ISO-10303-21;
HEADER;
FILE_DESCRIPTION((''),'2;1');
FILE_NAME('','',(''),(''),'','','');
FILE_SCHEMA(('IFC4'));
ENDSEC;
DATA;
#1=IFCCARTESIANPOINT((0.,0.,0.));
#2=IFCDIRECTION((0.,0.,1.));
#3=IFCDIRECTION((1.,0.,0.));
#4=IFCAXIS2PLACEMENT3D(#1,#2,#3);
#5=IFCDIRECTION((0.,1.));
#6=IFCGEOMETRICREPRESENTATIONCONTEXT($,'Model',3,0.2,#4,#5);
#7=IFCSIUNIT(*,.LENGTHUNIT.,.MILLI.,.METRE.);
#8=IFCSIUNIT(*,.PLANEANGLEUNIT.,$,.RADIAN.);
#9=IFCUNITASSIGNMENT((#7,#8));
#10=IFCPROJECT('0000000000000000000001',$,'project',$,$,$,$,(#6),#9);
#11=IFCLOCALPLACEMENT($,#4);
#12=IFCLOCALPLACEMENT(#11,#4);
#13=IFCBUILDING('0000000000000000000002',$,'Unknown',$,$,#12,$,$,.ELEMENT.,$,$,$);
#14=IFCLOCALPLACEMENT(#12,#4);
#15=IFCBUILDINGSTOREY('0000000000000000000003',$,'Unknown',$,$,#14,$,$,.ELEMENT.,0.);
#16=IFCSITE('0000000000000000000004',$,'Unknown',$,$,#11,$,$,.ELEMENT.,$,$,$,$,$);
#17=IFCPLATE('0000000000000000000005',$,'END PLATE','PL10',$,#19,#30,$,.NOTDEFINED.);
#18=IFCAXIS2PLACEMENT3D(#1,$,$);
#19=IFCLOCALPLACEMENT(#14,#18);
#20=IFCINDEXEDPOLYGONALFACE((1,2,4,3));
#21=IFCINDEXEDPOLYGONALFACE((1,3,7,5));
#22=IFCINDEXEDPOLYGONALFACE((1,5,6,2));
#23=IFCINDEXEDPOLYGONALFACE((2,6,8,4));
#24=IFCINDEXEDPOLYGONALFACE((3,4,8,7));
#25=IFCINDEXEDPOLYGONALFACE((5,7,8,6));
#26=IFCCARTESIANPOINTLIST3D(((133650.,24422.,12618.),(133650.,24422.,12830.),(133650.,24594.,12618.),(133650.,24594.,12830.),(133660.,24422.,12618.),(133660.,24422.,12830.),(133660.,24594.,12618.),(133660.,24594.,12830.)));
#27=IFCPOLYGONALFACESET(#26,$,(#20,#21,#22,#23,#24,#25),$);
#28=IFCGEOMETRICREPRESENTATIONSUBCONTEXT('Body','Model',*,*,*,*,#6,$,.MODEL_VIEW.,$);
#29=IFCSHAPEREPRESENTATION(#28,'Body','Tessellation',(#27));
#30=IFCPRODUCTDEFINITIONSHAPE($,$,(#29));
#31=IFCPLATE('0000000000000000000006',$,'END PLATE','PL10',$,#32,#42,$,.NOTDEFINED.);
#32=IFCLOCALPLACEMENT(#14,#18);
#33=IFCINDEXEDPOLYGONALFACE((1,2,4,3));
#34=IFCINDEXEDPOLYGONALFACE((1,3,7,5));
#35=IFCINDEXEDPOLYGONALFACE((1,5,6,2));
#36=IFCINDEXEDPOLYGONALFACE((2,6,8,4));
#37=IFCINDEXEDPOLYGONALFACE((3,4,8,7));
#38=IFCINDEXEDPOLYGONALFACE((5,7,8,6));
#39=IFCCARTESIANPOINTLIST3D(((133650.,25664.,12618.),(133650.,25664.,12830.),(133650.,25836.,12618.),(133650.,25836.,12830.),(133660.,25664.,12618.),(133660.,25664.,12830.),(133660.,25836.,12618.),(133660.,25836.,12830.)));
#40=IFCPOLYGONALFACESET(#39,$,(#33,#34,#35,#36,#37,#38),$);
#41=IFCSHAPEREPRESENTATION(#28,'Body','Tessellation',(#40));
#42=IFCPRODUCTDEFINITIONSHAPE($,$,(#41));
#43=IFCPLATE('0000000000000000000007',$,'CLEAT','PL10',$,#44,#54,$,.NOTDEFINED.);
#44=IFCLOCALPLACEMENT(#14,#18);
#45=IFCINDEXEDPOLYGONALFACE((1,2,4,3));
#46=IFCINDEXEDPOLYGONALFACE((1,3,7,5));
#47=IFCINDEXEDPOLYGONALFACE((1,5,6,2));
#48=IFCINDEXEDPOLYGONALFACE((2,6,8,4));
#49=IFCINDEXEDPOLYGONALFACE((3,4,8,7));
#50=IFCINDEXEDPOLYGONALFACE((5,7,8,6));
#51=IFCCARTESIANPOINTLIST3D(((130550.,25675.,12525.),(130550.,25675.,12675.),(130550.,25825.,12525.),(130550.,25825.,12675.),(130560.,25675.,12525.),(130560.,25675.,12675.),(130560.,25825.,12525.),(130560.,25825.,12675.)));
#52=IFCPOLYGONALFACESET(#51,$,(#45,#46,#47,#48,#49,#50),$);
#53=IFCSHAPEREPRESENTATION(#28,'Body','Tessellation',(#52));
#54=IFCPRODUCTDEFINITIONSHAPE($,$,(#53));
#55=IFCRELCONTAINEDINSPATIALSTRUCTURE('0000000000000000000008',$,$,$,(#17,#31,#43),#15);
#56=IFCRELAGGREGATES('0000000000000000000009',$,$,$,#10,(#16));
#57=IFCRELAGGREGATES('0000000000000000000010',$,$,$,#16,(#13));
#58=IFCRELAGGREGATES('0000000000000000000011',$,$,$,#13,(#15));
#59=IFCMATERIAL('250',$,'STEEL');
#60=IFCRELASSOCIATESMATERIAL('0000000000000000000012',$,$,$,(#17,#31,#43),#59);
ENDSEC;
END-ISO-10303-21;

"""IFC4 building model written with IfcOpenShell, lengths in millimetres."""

from ifc_helpers import new_model, si_unit, direction, frame, origin_with_axes, place, context, subcontext, project, spatial, line, indexed_curve, outline, extrude, material, element, save


model = new_model("IFC4")

# Units and contexts
model_context = context("Model", 3, precision=0.2, world=origin_with_axes(), true_north=direction((0.0, 1.0)))
body_context = subcontext(model_context, "Body", "Model", "MODEL_VIEW")
ifc_project = project(units=[si_unit("LENGTHUNIT", "METRE", prefix="MILLI"), si_unit("PLANEANGLEUNIT", "RADIAN")], contexts=[model_context])

# Site, building, storey
site_placement = place(None, origin_with_axes())
site = spatial("IfcSite", under=ifc_project, at=site_placement, Name="Unknown", CompositionType="ELEMENT")
building_placement = place(site_placement, origin_with_axes())
building = spatial("IfcBuilding", under=site, at=building_placement, Name="Unknown", CompositionType="ELEMENT")
storey_placement = place(building_placement, origin_with_axes())
storey = spatial("IfcBuildingStorey", under=building, at=storey_placement, Name="Unknown", CompositionType="ELEMENT", Elevation=0.0)

# Plates
ifc_material_1 = material(Name="250", Category="STEEL")
for number, where, z_axis, x_axis, name in (
    (1, (133655.0, 24594.0, 12618.0), (-1.0, 0.0, 0.0), (0.0, -1.0, 0.0), "END PLATE"),
    (2, (133655.0, 25836.0, 12618.0), (-1.0, 0.0, 0.0), (0.0, -1.0, 0.0), "END PLATE"),
):
    element("IfcPlate", number, at=place(storey_placement, frame(where, z_axis=z_axis, x_axis=x_axis)), inside=storey, material=ifc_material_1, Name=name, Description="PL10", PredefinedType="NOTDEFINED", context=body_context, shape_type="SolidModel", body=[
        extrude(outline(indexed_curve([(0.0, 0.0), (172.0, 0.0), (172.0, 212.0), (0.0, 212.0)], segments=[line(1, 2, 3, 4, 1)])), frame((0.0, 0.0, 5.0), z_axis=(0.0, 0.0, 1.0), x_axis=(1.0, 0.0, 0.0)), (0.0, 0.0, -1.0), 10.0),
    ])
plate_1_placement = place(storey_placement, frame((130555.0, 25675.0, 12525.0), z_axis=(1.0, 0.0, 0.0), x_axis=(0.0, 1.0, 0.0)))
element("IfcPlate", 3, at=plate_1_placement, inside=storey, material=ifc_material_1, Name="CLEAT", Description="PL10", PredefinedType="NOTDEFINED", context=body_context, shape_type="SolidModel", body=[
    extrude(outline(indexed_curve([(0.0, 0.0), (150.0, 0.0), (150.0, 150.0), (0.0, 150.0)], segments=[line(1, 2, 3, 4, 1)])), frame((0.0, 0.0, 5.0), z_axis=(0.0, 0.0, 1.0), x_axis=(1.0, 0.0, 0.0)), (0.0, 0.0, -1.0), 10.0),
])

save(model, "model.ifc")
